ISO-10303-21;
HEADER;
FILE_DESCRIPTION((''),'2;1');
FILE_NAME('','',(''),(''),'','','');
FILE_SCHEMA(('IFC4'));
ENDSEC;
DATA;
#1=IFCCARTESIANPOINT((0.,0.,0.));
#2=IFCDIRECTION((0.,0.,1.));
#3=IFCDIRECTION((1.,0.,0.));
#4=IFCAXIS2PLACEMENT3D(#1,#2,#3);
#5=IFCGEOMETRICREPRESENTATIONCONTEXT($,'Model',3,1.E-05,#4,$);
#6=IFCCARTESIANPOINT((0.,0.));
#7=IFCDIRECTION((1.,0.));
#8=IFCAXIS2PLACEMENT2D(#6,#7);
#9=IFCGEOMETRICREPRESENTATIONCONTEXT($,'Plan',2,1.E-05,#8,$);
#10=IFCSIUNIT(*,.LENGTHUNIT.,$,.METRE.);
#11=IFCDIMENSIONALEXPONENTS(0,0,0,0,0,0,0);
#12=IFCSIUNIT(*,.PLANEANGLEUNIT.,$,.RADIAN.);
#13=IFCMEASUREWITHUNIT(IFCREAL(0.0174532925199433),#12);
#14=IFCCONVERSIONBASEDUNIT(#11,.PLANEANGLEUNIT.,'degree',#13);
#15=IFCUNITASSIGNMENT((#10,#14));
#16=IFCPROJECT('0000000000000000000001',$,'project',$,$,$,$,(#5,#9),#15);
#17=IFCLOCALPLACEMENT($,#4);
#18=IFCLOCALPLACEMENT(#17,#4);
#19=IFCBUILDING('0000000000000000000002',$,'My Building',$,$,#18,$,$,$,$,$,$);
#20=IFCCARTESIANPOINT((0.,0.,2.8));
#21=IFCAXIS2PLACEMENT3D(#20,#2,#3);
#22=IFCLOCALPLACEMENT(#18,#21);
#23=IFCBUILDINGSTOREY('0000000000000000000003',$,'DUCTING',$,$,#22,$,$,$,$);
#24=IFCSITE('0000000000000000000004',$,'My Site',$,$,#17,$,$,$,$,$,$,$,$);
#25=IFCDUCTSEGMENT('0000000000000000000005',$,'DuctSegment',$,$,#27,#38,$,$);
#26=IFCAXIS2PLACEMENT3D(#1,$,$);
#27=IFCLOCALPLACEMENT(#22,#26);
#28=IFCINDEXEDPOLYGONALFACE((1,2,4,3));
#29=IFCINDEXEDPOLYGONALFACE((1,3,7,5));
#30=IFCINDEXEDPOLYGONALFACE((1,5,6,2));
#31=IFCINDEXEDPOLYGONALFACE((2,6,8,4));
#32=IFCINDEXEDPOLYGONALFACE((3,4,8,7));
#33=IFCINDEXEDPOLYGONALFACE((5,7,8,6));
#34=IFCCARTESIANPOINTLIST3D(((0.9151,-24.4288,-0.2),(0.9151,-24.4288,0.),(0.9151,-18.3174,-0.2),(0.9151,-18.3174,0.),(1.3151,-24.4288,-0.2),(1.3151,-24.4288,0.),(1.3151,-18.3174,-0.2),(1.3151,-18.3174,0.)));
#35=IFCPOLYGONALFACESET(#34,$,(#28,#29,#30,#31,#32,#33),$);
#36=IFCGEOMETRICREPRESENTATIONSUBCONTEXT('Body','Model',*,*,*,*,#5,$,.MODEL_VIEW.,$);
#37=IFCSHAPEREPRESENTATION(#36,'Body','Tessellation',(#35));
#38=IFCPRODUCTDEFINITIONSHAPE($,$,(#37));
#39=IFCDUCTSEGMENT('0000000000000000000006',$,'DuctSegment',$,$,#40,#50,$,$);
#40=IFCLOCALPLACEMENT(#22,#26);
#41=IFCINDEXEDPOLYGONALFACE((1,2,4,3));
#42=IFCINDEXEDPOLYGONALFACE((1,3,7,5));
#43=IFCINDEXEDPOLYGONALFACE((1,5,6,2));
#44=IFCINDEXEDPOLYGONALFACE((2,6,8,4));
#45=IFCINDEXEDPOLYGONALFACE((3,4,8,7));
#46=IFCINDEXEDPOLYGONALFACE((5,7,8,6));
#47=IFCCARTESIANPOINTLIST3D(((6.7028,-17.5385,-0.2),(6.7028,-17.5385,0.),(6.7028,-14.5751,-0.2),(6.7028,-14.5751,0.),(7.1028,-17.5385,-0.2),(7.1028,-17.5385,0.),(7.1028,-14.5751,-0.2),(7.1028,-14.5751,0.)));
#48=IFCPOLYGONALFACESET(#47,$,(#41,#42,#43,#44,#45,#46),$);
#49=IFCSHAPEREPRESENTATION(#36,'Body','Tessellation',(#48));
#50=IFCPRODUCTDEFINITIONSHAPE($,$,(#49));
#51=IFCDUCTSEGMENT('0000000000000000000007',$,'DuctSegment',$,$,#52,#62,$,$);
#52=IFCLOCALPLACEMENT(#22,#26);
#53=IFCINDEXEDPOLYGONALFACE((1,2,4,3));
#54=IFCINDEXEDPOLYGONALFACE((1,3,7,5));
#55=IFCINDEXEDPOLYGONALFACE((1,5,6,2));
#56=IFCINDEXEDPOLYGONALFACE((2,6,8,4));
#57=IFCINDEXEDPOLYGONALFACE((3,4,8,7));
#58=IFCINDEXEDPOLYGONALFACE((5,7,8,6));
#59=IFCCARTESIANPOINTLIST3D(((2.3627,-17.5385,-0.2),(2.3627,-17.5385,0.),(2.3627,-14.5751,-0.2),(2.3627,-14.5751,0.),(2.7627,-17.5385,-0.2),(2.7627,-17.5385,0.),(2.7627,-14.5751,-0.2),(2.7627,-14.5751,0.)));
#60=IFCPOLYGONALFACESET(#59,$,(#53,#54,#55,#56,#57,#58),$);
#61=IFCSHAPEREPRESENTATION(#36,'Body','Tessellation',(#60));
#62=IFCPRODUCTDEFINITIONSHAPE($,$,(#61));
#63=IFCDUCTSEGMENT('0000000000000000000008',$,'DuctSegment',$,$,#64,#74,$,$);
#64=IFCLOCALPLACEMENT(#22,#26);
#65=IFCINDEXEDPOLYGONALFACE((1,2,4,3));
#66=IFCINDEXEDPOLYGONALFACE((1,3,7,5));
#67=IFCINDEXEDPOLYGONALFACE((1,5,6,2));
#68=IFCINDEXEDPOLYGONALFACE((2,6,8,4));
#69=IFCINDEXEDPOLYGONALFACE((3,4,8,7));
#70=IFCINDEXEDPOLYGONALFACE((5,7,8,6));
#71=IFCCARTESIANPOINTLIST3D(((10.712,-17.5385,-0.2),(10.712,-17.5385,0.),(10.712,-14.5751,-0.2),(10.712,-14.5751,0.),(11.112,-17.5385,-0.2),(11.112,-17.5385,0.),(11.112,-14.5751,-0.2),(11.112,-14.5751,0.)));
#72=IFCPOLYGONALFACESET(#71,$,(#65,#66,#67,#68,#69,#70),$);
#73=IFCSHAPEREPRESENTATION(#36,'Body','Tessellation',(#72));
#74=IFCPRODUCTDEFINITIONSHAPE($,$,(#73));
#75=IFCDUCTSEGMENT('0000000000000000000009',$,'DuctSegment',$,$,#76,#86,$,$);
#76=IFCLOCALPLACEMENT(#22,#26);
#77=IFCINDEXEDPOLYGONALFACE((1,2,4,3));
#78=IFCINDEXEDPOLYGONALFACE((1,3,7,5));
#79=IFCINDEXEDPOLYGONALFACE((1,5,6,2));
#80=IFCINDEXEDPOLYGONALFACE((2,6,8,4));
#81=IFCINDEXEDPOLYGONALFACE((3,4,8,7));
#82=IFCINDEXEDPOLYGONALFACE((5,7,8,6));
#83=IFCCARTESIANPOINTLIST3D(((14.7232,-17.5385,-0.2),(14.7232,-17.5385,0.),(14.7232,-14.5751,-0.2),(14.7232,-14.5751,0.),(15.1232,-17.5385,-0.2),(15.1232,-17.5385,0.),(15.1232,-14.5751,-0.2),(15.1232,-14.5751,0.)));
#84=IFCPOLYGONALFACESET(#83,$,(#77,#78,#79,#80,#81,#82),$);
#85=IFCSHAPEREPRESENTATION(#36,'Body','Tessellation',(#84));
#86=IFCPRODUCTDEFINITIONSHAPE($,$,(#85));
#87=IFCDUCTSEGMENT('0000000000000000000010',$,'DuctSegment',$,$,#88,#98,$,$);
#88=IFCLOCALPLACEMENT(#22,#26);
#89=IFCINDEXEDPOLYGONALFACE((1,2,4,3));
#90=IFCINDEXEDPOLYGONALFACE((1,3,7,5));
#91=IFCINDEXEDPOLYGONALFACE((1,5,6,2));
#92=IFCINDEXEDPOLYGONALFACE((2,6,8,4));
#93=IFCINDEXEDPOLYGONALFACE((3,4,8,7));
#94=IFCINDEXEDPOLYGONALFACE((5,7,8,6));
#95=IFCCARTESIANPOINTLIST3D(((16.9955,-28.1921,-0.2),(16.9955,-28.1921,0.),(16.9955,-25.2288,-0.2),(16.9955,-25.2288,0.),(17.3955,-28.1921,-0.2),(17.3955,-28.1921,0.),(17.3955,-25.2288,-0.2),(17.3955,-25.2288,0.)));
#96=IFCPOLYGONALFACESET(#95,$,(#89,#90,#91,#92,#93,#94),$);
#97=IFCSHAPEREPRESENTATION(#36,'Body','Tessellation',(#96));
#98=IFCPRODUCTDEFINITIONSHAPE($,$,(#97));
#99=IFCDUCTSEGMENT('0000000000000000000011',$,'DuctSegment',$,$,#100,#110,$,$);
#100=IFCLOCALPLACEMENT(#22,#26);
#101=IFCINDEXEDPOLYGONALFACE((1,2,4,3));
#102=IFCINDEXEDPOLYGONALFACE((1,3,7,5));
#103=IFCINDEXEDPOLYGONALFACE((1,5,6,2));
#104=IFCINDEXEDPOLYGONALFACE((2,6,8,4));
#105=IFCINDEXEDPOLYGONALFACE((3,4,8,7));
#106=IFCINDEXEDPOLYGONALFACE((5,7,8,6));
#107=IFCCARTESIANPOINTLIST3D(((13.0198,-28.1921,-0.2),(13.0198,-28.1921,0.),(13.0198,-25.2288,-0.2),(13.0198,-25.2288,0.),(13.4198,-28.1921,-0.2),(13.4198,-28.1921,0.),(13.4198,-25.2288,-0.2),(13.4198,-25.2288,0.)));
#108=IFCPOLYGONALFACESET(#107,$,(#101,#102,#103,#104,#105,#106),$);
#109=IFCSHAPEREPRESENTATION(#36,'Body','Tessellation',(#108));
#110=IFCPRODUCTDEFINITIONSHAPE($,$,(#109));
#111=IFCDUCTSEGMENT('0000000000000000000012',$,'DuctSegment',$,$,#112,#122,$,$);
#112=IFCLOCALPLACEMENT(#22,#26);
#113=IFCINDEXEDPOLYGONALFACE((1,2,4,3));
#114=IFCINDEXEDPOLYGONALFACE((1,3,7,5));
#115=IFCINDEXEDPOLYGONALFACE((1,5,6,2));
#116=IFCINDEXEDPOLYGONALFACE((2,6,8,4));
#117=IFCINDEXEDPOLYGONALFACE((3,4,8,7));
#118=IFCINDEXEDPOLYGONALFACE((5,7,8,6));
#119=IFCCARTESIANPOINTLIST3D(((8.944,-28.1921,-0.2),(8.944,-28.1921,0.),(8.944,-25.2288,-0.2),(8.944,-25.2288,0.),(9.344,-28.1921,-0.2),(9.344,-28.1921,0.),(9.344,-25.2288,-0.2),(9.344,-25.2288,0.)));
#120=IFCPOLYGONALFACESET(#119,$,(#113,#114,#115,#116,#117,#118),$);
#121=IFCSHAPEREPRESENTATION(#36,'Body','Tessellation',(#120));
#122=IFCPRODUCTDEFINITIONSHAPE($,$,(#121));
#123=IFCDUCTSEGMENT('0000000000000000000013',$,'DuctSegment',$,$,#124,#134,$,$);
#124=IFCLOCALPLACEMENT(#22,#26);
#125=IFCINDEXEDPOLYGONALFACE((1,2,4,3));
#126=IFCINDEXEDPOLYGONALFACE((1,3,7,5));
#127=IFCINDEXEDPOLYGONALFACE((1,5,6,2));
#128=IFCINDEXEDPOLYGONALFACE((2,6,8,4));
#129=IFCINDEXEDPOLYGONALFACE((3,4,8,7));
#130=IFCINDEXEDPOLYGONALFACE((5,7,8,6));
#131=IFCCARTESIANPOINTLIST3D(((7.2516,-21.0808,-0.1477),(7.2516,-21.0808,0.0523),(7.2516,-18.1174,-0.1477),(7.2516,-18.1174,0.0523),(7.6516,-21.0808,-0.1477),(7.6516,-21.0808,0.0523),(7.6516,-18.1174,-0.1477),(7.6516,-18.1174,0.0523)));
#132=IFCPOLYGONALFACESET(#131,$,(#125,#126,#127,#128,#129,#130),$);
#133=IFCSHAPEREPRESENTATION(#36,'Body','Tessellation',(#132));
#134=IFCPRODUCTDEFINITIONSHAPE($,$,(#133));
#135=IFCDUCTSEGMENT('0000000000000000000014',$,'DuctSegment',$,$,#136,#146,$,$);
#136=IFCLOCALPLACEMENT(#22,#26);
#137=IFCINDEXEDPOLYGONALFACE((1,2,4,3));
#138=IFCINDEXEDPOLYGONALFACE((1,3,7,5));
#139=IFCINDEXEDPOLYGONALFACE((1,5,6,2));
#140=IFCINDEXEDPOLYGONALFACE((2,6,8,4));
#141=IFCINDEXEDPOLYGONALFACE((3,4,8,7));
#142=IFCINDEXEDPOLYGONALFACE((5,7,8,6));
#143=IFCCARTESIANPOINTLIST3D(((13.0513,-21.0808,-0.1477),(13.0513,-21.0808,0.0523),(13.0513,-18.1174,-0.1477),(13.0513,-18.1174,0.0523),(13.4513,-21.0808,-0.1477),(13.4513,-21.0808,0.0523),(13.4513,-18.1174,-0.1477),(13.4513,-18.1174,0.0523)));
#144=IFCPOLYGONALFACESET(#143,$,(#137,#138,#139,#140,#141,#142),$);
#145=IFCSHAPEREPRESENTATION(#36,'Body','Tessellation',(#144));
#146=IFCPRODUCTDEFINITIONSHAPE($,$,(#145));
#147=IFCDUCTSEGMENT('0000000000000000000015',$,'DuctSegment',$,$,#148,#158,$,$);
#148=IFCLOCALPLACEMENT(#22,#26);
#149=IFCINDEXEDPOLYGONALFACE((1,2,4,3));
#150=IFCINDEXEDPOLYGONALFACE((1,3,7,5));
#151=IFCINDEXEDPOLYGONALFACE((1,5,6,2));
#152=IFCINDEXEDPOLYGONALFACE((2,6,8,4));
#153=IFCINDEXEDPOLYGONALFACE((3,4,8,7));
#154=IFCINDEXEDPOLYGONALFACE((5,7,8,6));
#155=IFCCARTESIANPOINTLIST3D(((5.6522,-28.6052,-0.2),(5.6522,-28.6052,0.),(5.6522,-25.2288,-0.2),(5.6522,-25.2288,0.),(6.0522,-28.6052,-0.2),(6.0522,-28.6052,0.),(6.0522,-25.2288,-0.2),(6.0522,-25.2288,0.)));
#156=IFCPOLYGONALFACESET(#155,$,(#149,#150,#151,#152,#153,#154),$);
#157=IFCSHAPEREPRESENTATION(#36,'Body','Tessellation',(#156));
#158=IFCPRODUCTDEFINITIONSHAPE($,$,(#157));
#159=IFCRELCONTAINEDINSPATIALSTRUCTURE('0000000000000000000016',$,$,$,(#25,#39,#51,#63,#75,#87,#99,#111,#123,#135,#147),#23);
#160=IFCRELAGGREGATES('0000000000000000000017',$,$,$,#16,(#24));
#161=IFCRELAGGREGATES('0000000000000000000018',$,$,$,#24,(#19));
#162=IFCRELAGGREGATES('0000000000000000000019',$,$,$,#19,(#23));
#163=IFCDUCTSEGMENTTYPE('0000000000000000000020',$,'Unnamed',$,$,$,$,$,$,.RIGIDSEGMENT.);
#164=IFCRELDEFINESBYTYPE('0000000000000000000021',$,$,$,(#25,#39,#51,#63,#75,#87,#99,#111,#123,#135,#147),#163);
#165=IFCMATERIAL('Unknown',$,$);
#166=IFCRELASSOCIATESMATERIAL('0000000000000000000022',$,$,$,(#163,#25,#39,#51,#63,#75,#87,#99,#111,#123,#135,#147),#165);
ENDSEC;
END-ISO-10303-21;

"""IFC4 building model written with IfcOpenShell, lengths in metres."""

from ifc_helpers import new_model, entity, si_unit, converted_unit, frame, origin_with_axes, origin_2d_with_axis, place, context, subcontext, project, spatial, rectangle, extrude, material, material_profile, profile_set, profile_usage, type_object, element, save


model = new_model("IFC4")

# Units and contexts
model_context = context("Model", 3, precision=1e-05, world=origin_with_axes())
plan_context = context("Plan", 2, precision=1e-05, world=origin_2d_with_axis())
body_context = subcontext(model_context, "Body", "Model", "MODEL_VIEW")
ifc_project = project(units=[si_unit("LENGTHUNIT", "METRE"), converted_unit("PLANEANGLEUNIT", "degree", entity("IfcReal", 0.0174532925199433), si_unit("PLANEANGLEUNIT", "RADIAN"), dimensions=[0, 0, 0, 0, 0, 0, 0])], contexts=[model_context, plan_context])

# Site, building, storey
site_placement = place(None, origin_with_axes())
site = spatial("IfcSite", under=ifc_project, at=site_placement, Name="My Site")
building_placement = place(site_placement, origin_with_axes())
building = spatial("IfcBuilding", under=site, at=building_placement, Name="My Building")
storey_placement = place(building_placement, frame((0.0, 0.0, 2.8), z_axis=(0.0, 0.0, 1.0), x_axis=(1.0, 0.0, 0.0)))
storey = spatial("IfcBuildingStorey", under=building, at=storey_placement, Name="DUCTING")

# Duct segments
ifc_material = material(Name="Unknown")
ifc_material_profile_1 = material_profile(ifc_material, rectangle(XDim=0.4, YDim=0.2))
ifc_profile_set_1 = profile_set([ifc_material_profile_1])
ifc_profile_usage_1 = profile_usage(ifc_profile_set_1, cardinal=5)
duct_segment_type = type_object("IfcDuctSegmentType", Name="Unnamed", PredefinedType="RIGIDSEGMENT", material=ifc_profile_set_1)
duct_segment_1_placement = place(storey_placement, frame((1.1151, -24.4288, -0.1), z_axis=(0.0, 1.0, 0.0), x_axis=(-1.0, 0.0, 0.0)))
element("IfcDuctSegment", 1, at=duct_segment_1_placement, inside=storey, type_object=duct_segment_type, material=ifc_profile_usage_1, Name="DuctSegment", context=body_context, shape_type="SweptSolid", body=[
    extrude(rectangle(XDim=0.4, YDim=0.2), origin_with_axes(), (0.0, 0.0, 1.0), 6.1113),
])
ifc_profile_usage_2 = profile_usage(ifc_profile_set_1, cardinal=5)
duct_segment_2_placement = place(storey_placement, frame((6.9028, -14.5751, -0.1), z_axis=(0.0, -1.0, 0.0), x_axis=(1.0, 0.0, 0.0)))
element("IfcDuctSegment", 2, at=duct_segment_2_placement, inside=storey, type_object=duct_segment_type, material=ifc_profile_usage_2, Name="DuctSegment", context=body_context, shape_type="SweptSolid", body=[
    extrude(rectangle(XDim=0.4, YDim=0.2), origin_with_axes(), (0.0, 0.0, 1.0), 2.9634),
])
ifc_profile_usage_3 = profile_usage(ifc_profile_set_1, cardinal=5)
duct_segment_3_placement = place(storey_placement, frame((2.5627, -14.5751, -0.1), z_axis=(0.0, -1.0, 0.0), x_axis=(1.0, 0.0, 0.0)))
element("IfcDuctSegment", 3, at=duct_segment_3_placement, inside=storey, type_object=duct_segment_type, material=ifc_profile_usage_3, Name="DuctSegment", context=body_context, shape_type="SweptSolid", body=[
    extrude(rectangle(XDim=0.4, YDim=0.2), origin_with_axes(), (0.0, 0.0, 1.0), 2.9634),
])
ifc_profile_usage_4 = profile_usage(ifc_profile_set_1, cardinal=5)
duct_segment_4_placement = place(storey_placement, frame((10.912, -14.5751, -0.1), z_axis=(0.0, -1.0, 0.0), x_axis=(1.0, 0.0, 0.0)))
element("IfcDuctSegment", 4, at=duct_segment_4_placement, inside=storey, type_object=duct_segment_type, material=ifc_profile_usage_4, Name="DuctSegment", context=body_context, shape_type="SweptSolid", body=[
    extrude(rectangle(XDim=0.4, YDim=0.2), origin_with_axes(), (0.0, 0.0, 1.0), 2.9634),
])
ifc_profile_usage_5 = profile_usage(ifc_profile_set_1, cardinal=5)
duct_segment_5_placement = place(storey_placement, frame((14.9232, -14.5751, -0.1), z_axis=(0.0, -1.0, 0.0), x_axis=(1.0, 0.0, 0.0)))
element("IfcDuctSegment", 5, at=duct_segment_5_placement, inside=storey, type_object=duct_segment_type, material=ifc_profile_usage_5, Name="DuctSegment", context=body_context, shape_type="SweptSolid", body=[
    extrude(rectangle(XDim=0.4, YDim=0.2), origin_with_axes(), (0.0, 0.0, 1.0), 2.9634),
])
ifc_profile_usage_6 = profile_usage(ifc_profile_set_1, cardinal=5)
duct_segment_6_placement = place(storey_placement, frame((17.1955, -28.1921, -0.1), z_axis=(0.0, 1.0, 0.0), x_axis=(-1.0, 0.0, 0.0)))
element("IfcDuctSegment", 6, at=duct_segment_6_placement, inside=storey, type_object=duct_segment_type, material=ifc_profile_usage_6, Name="DuctSegment", context=body_context, shape_type="SweptSolid", body=[
    extrude(rectangle(XDim=0.4, YDim=0.2), origin_with_axes(), (0.0, 0.0, 1.0), 2.9634),
])
ifc_profile_usage_7 = profile_usage(ifc_profile_set_1, cardinal=5)
duct_segment_7_placement = place(storey_placement, frame((13.2198, -28.1921, -0.1), z_axis=(0.0, 1.0, 0.0), x_axis=(-1.0, 0.0, 0.0)))
element("IfcDuctSegment", 7, at=duct_segment_7_placement, inside=storey, type_object=duct_segment_type, material=ifc_profile_usage_7, Name="DuctSegment", context=body_context, shape_type="SweptSolid", body=[
    extrude(rectangle(XDim=0.4, YDim=0.2), origin_with_axes(), (0.0, 0.0, 1.0), 2.9634),
])
ifc_profile_usage_8 = profile_usage(ifc_profile_set_1, cardinal=5)
duct_segment_8_placement = place(storey_placement, frame((9.144, -28.1921, -0.1), z_axis=(0.0, 1.0, 0.0), x_axis=(-1.0, 0.0, 0.0)))
element("IfcDuctSegment", 8, at=duct_segment_8_placement, inside=storey, type_object=duct_segment_type, material=ifc_profile_usage_8, Name="DuctSegment", context=body_context, shape_type="SweptSolid", body=[
    extrude(rectangle(XDim=0.4, YDim=0.2), origin_with_axes(), (0.0, 0.0, 1.0), 2.9634),
])
ifc_profile_usage_9 = profile_usage(ifc_profile_set_1, cardinal=5)
duct_segment_9_placement = place(storey_placement, frame((7.4516, -21.0808, -0.0477), z_axis=(0.0, 1.0, 0.0), x_axis=(-1.0, 0.0, 0.0)))
element("IfcDuctSegment", 9, at=duct_segment_9_placement, inside=storey, type_object=duct_segment_type, material=ifc_profile_usage_9, Name="DuctSegment", context=body_context, shape_type="SweptSolid", body=[
    extrude(rectangle(XDim=0.4, YDim=0.2), origin_with_axes(), (0.0, 0.0, 1.0), 2.9634),
])
ifc_profile_usage_10 = profile_usage(ifc_profile_set_1, cardinal=5)
duct_segment_10_placement = place(storey_placement, frame((13.2513, -21.0808, -0.0477), z_axis=(0.0, 1.0, 0.0), x_axis=(-1.0, 0.0, 0.0)))
element("IfcDuctSegment", 10, at=duct_segment_10_placement, inside=storey, type_object=duct_segment_type, material=ifc_profile_usage_10, Name="DuctSegment", context=body_context, shape_type="SweptSolid", body=[
    extrude(rectangle(XDim=0.4, YDim=0.2), origin_with_axes(), (0.0, 0.0, 1.0), 2.9634),
])
ifc_profile_usage_11 = profile_usage(ifc_profile_set_1, cardinal=5)
duct_segment_11_placement = place(storey_placement, frame((5.8522, -28.6052, -0.1), z_axis=(0.0, 1.0, 0.0), x_axis=(-1.0, 0.0, 0.0)))
element("IfcDuctSegment", 11, at=duct_segment_11_placement, inside=storey, type_object=duct_segment_type, material=ifc_profile_usage_11, Name="DuctSegment", context=body_context, shape_type="SweptSolid", body=[
    extrude(rectangle(XDim=0.4, YDim=0.2), origin_with_axes(), (0.0, 0.0, 1.0), 3.3764),
])

save(model, "model.ifc")
